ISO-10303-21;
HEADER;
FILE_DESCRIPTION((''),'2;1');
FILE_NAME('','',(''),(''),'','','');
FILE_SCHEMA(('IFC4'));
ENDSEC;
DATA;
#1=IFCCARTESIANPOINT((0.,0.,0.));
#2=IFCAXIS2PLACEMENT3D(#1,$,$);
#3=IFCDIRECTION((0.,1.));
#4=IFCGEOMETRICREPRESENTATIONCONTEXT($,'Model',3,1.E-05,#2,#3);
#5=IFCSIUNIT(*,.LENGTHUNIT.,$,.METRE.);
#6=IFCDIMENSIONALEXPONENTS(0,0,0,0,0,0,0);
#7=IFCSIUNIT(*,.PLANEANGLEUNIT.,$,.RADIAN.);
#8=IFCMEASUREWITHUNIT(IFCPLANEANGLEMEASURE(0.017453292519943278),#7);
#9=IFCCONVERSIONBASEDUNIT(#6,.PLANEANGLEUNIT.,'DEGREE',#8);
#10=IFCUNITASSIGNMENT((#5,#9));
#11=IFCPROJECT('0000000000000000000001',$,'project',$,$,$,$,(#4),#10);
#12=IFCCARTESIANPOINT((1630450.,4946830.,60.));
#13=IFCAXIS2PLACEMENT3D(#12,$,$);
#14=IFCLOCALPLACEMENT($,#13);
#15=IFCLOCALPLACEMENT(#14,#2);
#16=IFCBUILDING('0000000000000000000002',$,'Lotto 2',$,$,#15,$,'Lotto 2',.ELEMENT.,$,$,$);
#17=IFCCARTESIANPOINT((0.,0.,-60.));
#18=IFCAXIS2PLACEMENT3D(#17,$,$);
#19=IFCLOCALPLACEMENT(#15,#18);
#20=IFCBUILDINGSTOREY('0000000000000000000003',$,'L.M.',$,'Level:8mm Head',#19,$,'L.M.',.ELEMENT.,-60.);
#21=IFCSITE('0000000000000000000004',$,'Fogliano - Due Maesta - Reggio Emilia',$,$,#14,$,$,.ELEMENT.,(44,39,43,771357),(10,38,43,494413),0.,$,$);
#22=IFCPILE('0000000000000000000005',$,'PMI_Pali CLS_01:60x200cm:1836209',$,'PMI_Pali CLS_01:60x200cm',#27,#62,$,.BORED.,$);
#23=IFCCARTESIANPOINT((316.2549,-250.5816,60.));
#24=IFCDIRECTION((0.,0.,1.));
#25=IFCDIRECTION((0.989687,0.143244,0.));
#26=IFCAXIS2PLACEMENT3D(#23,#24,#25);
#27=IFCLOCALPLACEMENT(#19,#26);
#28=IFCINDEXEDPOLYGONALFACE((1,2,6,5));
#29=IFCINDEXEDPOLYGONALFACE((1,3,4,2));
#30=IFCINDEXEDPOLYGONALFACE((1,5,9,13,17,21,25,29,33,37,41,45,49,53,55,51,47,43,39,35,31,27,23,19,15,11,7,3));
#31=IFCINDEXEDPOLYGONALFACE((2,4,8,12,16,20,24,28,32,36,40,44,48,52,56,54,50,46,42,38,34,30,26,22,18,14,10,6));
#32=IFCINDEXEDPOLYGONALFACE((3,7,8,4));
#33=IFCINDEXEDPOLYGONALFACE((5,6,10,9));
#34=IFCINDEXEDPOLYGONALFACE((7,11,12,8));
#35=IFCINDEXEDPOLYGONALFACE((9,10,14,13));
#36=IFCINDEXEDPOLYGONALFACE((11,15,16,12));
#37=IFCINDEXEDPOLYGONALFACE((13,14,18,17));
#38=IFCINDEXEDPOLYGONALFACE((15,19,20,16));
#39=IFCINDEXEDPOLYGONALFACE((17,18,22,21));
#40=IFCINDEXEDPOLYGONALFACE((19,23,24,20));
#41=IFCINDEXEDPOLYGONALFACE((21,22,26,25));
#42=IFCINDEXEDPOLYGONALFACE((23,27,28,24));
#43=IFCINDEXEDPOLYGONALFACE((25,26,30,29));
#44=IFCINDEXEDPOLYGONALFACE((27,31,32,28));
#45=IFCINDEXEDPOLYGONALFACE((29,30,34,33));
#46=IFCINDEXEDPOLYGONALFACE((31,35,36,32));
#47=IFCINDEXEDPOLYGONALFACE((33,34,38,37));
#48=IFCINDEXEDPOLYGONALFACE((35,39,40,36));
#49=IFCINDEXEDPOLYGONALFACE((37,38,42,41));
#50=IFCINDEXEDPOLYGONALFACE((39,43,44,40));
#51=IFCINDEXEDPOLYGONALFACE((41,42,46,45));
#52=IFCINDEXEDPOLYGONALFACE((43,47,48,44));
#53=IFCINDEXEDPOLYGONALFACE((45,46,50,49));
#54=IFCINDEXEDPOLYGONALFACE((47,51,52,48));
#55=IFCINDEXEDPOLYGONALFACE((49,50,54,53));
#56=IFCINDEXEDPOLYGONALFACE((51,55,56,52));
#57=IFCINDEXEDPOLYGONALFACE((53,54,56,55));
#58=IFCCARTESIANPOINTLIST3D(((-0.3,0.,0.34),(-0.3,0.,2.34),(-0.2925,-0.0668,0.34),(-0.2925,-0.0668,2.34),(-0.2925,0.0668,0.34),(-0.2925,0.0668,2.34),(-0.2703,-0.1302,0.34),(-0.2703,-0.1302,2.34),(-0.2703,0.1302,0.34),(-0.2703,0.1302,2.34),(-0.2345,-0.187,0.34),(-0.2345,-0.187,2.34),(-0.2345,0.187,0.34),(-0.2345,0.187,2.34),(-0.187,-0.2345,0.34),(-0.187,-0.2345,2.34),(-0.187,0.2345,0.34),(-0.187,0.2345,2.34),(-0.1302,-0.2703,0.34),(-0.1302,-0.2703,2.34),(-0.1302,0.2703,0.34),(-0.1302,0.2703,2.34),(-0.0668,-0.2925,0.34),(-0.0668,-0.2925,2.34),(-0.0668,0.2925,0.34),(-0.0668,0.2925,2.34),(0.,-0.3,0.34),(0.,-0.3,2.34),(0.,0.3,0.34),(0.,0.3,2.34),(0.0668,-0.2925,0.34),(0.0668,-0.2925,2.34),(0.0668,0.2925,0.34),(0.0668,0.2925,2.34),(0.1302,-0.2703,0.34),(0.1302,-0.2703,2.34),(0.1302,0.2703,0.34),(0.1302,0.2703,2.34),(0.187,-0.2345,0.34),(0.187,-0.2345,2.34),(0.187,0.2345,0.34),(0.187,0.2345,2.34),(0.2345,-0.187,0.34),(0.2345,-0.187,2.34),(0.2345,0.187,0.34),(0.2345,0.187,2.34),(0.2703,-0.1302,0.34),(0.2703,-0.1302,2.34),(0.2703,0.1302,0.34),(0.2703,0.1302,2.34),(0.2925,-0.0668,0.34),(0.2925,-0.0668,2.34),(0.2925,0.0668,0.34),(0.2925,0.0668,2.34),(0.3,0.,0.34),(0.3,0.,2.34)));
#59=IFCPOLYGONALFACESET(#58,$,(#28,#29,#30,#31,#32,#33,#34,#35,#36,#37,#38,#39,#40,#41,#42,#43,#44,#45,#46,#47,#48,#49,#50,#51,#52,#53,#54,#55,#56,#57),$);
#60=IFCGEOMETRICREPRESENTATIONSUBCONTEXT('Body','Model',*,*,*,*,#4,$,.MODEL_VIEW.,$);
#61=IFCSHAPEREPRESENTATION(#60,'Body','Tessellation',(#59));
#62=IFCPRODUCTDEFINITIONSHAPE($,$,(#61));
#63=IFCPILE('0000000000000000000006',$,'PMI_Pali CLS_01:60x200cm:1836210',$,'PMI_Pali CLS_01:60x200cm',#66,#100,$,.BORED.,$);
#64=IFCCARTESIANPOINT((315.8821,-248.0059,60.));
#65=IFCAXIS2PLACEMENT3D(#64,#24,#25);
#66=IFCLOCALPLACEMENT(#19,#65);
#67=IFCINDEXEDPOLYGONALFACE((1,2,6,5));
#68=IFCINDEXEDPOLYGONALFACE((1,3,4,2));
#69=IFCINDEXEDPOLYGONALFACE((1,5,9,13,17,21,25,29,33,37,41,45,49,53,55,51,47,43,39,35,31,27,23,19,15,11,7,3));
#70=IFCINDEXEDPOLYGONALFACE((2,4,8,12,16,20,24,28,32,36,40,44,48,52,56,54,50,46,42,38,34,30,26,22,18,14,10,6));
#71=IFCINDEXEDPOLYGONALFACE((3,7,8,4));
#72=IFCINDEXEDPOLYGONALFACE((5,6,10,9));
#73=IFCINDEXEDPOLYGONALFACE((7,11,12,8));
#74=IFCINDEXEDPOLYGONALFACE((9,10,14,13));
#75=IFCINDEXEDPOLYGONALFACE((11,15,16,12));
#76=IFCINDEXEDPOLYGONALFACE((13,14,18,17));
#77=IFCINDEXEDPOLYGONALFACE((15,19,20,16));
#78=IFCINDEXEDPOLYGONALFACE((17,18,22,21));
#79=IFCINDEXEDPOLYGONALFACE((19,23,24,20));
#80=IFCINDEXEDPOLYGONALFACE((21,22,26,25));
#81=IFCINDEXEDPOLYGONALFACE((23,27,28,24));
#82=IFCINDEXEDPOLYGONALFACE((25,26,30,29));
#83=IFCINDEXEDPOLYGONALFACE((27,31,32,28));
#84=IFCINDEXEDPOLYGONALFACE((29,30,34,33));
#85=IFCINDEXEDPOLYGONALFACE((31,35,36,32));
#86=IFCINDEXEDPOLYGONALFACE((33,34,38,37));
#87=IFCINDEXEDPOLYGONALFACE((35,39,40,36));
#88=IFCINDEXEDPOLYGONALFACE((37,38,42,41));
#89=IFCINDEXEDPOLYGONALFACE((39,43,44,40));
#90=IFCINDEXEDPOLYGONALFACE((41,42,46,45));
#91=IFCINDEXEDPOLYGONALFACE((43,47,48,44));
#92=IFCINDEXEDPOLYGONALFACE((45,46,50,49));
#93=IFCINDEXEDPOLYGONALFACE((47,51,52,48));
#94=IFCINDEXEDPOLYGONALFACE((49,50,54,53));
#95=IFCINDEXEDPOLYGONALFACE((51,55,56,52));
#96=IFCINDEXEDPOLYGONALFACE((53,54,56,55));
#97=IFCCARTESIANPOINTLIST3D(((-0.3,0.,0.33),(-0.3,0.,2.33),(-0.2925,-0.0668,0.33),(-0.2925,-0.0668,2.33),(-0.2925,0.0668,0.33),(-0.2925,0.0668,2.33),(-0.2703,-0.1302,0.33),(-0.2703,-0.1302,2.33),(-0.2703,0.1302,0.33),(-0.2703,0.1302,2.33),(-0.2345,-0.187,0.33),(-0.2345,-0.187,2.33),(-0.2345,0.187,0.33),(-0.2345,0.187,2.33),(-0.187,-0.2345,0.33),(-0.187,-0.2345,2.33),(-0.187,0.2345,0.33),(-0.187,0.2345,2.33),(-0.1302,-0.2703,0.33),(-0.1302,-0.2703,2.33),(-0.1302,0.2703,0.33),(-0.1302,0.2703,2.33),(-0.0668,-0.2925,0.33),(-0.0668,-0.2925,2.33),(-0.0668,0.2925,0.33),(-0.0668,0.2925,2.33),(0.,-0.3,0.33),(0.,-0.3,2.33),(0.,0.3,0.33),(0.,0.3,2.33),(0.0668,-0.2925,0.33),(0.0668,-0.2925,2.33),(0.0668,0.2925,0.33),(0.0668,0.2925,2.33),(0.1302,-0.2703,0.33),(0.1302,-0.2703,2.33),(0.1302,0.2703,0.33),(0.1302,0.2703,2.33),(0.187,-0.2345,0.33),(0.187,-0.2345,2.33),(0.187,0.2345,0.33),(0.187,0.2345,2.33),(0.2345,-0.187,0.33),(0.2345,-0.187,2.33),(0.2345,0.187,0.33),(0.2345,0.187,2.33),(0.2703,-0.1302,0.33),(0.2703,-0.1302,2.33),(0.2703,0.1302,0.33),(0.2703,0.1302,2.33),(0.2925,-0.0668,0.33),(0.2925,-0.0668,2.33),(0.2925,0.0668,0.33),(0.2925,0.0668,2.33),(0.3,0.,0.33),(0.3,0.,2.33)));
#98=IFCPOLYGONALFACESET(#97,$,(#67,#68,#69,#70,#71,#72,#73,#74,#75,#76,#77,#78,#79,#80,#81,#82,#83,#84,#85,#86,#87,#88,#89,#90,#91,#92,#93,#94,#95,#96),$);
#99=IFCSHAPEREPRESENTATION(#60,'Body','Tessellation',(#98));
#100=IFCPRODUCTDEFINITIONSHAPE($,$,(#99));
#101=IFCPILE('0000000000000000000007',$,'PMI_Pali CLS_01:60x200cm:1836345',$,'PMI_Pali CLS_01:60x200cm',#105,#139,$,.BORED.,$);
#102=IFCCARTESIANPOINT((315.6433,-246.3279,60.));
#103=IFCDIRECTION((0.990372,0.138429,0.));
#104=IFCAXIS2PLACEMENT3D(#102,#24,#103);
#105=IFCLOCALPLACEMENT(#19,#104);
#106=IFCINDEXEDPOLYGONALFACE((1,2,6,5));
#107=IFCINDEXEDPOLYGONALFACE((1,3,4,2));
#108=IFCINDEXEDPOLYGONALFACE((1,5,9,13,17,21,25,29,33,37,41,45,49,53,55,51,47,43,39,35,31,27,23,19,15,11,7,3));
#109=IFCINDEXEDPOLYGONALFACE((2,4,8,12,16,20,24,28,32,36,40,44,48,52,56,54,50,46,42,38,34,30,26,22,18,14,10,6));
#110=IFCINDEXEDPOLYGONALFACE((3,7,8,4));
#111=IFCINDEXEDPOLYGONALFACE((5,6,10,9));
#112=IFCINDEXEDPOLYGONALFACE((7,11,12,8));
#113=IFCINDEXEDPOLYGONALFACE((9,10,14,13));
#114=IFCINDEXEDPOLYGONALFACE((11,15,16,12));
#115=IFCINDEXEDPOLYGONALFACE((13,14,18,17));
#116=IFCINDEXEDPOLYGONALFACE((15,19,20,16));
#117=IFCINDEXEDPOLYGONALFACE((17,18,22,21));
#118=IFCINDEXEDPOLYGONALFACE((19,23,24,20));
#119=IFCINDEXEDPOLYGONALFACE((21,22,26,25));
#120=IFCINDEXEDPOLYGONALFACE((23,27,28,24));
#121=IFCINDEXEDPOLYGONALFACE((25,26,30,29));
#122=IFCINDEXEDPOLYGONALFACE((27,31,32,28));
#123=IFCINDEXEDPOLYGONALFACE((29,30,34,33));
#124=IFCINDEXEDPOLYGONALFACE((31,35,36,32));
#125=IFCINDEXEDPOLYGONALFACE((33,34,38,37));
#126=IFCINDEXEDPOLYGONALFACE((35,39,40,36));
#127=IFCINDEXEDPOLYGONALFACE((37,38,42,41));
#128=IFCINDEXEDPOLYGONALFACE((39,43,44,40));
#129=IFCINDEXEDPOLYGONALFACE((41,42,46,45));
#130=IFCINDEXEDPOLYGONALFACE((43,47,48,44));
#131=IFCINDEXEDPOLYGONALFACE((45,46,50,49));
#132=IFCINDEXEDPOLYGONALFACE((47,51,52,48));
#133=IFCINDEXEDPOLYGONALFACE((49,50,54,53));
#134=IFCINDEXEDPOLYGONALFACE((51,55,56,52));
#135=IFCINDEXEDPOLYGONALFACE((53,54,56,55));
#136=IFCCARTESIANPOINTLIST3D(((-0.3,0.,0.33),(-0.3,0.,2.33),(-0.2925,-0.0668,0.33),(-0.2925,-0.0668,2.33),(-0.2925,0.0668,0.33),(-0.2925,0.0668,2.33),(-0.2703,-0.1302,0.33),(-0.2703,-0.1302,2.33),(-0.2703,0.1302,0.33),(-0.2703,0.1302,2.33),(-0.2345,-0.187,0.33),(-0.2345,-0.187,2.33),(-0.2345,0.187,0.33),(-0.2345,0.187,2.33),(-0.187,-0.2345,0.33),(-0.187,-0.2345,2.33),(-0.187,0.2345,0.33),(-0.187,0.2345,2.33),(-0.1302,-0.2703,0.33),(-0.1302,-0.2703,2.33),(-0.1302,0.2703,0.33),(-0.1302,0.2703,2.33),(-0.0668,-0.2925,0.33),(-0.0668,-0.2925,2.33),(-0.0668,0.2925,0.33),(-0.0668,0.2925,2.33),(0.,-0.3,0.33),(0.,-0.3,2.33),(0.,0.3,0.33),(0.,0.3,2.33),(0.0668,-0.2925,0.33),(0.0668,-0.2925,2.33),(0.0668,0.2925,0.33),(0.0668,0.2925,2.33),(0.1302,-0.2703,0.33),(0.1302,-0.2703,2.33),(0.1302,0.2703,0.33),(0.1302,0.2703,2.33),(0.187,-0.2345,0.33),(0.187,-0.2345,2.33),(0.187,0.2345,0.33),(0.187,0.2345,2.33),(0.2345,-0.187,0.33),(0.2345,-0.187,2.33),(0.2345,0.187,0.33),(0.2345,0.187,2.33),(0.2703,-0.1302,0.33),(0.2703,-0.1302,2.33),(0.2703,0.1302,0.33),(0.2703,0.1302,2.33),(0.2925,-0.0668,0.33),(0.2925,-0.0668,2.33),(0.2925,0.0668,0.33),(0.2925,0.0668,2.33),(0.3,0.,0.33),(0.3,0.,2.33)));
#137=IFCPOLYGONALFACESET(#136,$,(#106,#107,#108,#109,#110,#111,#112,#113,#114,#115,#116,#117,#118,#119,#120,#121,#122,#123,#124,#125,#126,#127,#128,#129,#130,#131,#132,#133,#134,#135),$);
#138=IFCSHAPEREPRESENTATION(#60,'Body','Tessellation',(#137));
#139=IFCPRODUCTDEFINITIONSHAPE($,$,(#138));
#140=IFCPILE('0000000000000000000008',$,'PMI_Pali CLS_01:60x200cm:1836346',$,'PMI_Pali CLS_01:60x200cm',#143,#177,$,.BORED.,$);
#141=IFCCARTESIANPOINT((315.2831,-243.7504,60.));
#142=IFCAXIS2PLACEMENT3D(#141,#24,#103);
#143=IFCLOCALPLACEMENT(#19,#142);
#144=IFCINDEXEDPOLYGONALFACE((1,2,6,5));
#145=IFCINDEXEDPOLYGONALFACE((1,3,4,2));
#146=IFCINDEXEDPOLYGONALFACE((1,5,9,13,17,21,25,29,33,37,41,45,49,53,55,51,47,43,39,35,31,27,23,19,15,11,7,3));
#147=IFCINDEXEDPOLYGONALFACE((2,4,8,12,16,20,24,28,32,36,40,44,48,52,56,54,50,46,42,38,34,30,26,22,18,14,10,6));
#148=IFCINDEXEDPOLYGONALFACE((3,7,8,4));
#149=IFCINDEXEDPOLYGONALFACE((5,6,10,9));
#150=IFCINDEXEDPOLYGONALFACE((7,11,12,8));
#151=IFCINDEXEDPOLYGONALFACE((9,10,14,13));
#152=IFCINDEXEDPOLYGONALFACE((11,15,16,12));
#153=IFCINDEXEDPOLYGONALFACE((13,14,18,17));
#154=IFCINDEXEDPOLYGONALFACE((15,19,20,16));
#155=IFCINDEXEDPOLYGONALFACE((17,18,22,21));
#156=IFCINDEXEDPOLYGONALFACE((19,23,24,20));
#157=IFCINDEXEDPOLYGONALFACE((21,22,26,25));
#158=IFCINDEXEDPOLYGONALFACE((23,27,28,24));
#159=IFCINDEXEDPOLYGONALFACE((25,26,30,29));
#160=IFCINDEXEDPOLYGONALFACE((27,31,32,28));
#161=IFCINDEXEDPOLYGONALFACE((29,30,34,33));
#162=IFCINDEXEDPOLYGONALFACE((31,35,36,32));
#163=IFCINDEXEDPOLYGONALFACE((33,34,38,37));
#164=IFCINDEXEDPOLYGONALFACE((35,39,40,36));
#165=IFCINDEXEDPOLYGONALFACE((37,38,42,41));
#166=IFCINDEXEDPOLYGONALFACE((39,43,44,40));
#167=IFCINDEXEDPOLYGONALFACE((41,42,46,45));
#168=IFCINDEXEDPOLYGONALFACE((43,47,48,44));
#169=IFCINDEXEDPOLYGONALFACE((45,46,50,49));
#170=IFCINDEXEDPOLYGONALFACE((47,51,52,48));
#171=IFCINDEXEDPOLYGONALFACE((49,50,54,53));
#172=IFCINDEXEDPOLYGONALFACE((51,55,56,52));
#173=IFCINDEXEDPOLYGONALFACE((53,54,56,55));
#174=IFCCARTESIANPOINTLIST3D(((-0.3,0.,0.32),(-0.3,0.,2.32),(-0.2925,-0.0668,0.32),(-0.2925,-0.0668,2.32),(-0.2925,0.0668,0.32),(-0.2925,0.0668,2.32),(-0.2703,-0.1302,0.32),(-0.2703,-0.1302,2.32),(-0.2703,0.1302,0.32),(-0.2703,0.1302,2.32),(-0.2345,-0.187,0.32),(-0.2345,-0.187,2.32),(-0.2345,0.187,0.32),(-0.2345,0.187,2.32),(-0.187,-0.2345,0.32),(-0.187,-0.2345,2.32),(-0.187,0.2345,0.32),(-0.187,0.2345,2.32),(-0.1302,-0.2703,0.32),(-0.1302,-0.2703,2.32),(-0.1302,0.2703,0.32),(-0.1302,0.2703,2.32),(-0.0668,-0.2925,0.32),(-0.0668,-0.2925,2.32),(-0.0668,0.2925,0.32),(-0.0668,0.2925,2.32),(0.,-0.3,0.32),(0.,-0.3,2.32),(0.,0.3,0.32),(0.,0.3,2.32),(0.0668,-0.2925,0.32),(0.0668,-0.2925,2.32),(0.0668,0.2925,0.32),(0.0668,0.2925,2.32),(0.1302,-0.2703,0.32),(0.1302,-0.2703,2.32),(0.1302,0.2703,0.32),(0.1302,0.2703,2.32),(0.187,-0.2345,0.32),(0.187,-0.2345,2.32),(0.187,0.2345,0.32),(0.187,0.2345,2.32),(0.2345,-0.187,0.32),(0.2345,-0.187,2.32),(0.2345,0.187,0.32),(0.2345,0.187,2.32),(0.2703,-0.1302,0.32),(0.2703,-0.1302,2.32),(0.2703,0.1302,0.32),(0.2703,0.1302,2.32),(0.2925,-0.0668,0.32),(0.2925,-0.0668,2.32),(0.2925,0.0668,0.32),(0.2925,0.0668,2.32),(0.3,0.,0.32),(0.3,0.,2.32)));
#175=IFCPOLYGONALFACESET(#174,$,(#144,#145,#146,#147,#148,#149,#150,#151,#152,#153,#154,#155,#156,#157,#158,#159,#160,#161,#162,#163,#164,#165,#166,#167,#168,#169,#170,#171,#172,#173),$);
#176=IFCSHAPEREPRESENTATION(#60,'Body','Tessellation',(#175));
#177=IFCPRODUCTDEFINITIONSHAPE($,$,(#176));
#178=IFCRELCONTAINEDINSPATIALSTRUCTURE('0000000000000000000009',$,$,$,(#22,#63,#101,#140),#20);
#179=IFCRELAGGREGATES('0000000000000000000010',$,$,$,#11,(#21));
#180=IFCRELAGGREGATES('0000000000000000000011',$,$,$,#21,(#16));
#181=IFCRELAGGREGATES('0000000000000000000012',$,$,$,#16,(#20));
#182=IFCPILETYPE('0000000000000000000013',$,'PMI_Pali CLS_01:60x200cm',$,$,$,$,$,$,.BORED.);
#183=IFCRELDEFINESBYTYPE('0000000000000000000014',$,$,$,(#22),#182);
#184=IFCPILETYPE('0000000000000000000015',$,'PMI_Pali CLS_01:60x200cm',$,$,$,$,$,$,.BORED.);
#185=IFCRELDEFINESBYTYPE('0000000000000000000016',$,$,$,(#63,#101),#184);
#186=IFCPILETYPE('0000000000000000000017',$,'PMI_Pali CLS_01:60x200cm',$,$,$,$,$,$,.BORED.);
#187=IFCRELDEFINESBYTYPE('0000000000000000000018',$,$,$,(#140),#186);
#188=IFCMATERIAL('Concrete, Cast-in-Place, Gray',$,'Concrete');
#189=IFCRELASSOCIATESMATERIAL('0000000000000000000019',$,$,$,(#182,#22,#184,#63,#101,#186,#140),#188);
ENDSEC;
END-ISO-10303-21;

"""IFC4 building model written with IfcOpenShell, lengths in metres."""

from ifc_helpers import new_model, entity, si_unit, converted_unit, direction, frame, origin, place, context, subcontext, project, spatial, arc, indexed_curve, outline, extrude, source, transform, mapped, material, type_object, type_shapes, element, save


model = new_model("IFC4")

# Units and contexts
model_context = context("Model", 3, precision=1e-05, world=origin(), true_north=direction((0.0, 1.0)))
body_context = subcontext(model_context, "Body", "Model", "MODEL_VIEW")
ifc_project = project(units=[si_unit("LENGTHUNIT", "METRE"), converted_unit("PLANEANGLEUNIT", "DEGREE", entity("IfcPlaneAngleMeasure", 0.017453292519943278), si_unit("PLANEANGLEUNIT", "RADIAN"), dimensions=[0, 0, 0, 0, 0, 0, 0])], contexts=[model_context])

# Site, building, storey
site_placement = place(None, frame((1630450.0, 4946830.0, 60.0)))
site = spatial("IfcSite", under=ifc_project, at=site_placement, Name="Fogliano - Due Maesta - Reggio Emilia", CompositionType="ELEMENT", RefLatitude=(44, 39, 43, 771357), RefLongitude=(10, 38, 43, 494413), RefElevation=0.0)
building_placement = place(site_placement, origin())
building = spatial("IfcBuilding", under=site, at=building_placement, Name="Lotto 2", LongName="Lotto 2", CompositionType="ELEMENT")
storey_placement = place(building_placement, frame((0.0, 0.0, -60.0)))
storey = spatial("IfcBuildingStorey", under=building, at=storey_placement, Name="L.M.", ObjectType="Level:8mm Head", LongName="L.M.", CompositionType="ELEMENT", Elevation=-60.0)

# Piles
ifc_material_1 = material(Name="Concrete, Cast-in-Place, Gray", Category="Concrete")
pile_type_1 = type_object("IfcPileType", Name="PMI_Pali CLS_01:60x200cm", PredefinedType="BORED", material=ifc_material_1)
shared_shape_1 = source(origin(), body_context, "Body", "SweptSolid", [
    extrude(outline(indexed_curve([(-0.3, 0.0), (0.0, -0.3), (0.3, 0.0), (0.0, 0.3)], segments=[arc(1, 2, 3), arc(3, 4, 1)], self_intersect=False)), frame((0.0, 0.0, 0.34)), (0.0, 0.0, 1.0), 2.0),
])
type_shapes(pile_type_1, [shared_shape_1])
pile_1_placement = place(storey_placement, frame((316.2549, -250.5816, 60.0), z_axis=(0.0, 0.0, 1.0), x_axis=(0.989687, 0.143244, 0.0)))
element("IfcPile", 1, at=pile_1_placement, inside=storey, type_object=pile_type_1, material=ifc_material_1, Name="PMI_Pali CLS_01:60x200cm:1836209", ObjectType="PMI_Pali CLS_01:60x200cm", PredefinedType="BORED", context=body_context, shape_type="MappedRepresentation", body=[
    mapped(shared_shape_1, transform((0.0, 0.0, 0.0), scale=1.0)),
])
pile_type_2 = type_object("IfcPileType", Name="PMI_Pali CLS_01:60x200cm", PredefinedType="BORED", material=ifc_material_1)
shared_shape_2 = source(origin(), body_context, "Body", "SweptSolid", [
    extrude(outline(indexed_curve([(-0.3, 0.0), (0.0, -0.3), (0.3, 0.0), (0.0, 0.3)], segments=[arc(1, 2, 3), arc(3, 4, 1)], self_intersect=False)), frame((0.0, 0.0, 0.33)), (0.0, 0.0, 1.0), 2.0),
])
type_shapes(pile_type_2, [shared_shape_2])
for number, where, z_axis, x_axis, name in (
    (2, (315.8821, -248.0059, 60.0), (0.0, 0.0, 1.0), (0.989687, 0.143244, 0.0), "PMI_Pali CLS_01:60x200cm:1836210"),
    (3, (315.6433, -246.3279, 60.0), (0.0, 0.0, 1.0), (0.990372, 0.138429, 0.0), "PMI_Pali CLS_01:60x200cm:1836345"),
):
    element("IfcPile", number, at=place(storey_placement, frame(where, z_axis=z_axis, x_axis=x_axis)), inside=storey, type_object=pile_type_2, material=ifc_material_1, Name=name, ObjectType="PMI_Pali CLS_01:60x200cm", PredefinedType="BORED", context=body_context, shape_type="MappedRepresentation", body=[
        mapped(shared_shape_2, transform((0.0, 0.0, 0.0), scale=1.0)),
    ])
pile_type_3 = type_object("IfcPileType", Name="PMI_Pali CLS_01:60x200cm", PredefinedType="BORED", material=ifc_material_1)
shared_shape_3 = source(origin(), body_context, "Body", "SweptSolid", [
    extrude(outline(indexed_curve([(-0.3, 0.0), (0.0, -0.3), (0.3, 0.0), (0.0, 0.3)], segments=[arc(1, 2, 3), arc(3, 4, 1)], self_intersect=False)), frame((0.0, 0.0, 0.32)), (0.0, 0.0, 1.0), 2.0),
])
type_shapes(pile_type_3, [shared_shape_3])
pile_2_placement = place(storey_placement, frame((315.2831, -243.7504, 60.0), z_axis=(0.0, 0.0, 1.0), x_axis=(0.990372, 0.138429, 0.0)))
element("IfcPile", 4, at=pile_2_placement, inside=storey, type_object=pile_type_3, material=ifc_material_1, Name="PMI_Pali CLS_01:60x200cm:1836346", ObjectType="PMI_Pali CLS_01:60x200cm", PredefinedType="BORED", context=body_context, shape_type="MappedRepresentation", body=[
    mapped(shared_shape_3, transform((0.0, 0.0, 0.0), scale=1.0)),
])

save(model, "model.ifc")
